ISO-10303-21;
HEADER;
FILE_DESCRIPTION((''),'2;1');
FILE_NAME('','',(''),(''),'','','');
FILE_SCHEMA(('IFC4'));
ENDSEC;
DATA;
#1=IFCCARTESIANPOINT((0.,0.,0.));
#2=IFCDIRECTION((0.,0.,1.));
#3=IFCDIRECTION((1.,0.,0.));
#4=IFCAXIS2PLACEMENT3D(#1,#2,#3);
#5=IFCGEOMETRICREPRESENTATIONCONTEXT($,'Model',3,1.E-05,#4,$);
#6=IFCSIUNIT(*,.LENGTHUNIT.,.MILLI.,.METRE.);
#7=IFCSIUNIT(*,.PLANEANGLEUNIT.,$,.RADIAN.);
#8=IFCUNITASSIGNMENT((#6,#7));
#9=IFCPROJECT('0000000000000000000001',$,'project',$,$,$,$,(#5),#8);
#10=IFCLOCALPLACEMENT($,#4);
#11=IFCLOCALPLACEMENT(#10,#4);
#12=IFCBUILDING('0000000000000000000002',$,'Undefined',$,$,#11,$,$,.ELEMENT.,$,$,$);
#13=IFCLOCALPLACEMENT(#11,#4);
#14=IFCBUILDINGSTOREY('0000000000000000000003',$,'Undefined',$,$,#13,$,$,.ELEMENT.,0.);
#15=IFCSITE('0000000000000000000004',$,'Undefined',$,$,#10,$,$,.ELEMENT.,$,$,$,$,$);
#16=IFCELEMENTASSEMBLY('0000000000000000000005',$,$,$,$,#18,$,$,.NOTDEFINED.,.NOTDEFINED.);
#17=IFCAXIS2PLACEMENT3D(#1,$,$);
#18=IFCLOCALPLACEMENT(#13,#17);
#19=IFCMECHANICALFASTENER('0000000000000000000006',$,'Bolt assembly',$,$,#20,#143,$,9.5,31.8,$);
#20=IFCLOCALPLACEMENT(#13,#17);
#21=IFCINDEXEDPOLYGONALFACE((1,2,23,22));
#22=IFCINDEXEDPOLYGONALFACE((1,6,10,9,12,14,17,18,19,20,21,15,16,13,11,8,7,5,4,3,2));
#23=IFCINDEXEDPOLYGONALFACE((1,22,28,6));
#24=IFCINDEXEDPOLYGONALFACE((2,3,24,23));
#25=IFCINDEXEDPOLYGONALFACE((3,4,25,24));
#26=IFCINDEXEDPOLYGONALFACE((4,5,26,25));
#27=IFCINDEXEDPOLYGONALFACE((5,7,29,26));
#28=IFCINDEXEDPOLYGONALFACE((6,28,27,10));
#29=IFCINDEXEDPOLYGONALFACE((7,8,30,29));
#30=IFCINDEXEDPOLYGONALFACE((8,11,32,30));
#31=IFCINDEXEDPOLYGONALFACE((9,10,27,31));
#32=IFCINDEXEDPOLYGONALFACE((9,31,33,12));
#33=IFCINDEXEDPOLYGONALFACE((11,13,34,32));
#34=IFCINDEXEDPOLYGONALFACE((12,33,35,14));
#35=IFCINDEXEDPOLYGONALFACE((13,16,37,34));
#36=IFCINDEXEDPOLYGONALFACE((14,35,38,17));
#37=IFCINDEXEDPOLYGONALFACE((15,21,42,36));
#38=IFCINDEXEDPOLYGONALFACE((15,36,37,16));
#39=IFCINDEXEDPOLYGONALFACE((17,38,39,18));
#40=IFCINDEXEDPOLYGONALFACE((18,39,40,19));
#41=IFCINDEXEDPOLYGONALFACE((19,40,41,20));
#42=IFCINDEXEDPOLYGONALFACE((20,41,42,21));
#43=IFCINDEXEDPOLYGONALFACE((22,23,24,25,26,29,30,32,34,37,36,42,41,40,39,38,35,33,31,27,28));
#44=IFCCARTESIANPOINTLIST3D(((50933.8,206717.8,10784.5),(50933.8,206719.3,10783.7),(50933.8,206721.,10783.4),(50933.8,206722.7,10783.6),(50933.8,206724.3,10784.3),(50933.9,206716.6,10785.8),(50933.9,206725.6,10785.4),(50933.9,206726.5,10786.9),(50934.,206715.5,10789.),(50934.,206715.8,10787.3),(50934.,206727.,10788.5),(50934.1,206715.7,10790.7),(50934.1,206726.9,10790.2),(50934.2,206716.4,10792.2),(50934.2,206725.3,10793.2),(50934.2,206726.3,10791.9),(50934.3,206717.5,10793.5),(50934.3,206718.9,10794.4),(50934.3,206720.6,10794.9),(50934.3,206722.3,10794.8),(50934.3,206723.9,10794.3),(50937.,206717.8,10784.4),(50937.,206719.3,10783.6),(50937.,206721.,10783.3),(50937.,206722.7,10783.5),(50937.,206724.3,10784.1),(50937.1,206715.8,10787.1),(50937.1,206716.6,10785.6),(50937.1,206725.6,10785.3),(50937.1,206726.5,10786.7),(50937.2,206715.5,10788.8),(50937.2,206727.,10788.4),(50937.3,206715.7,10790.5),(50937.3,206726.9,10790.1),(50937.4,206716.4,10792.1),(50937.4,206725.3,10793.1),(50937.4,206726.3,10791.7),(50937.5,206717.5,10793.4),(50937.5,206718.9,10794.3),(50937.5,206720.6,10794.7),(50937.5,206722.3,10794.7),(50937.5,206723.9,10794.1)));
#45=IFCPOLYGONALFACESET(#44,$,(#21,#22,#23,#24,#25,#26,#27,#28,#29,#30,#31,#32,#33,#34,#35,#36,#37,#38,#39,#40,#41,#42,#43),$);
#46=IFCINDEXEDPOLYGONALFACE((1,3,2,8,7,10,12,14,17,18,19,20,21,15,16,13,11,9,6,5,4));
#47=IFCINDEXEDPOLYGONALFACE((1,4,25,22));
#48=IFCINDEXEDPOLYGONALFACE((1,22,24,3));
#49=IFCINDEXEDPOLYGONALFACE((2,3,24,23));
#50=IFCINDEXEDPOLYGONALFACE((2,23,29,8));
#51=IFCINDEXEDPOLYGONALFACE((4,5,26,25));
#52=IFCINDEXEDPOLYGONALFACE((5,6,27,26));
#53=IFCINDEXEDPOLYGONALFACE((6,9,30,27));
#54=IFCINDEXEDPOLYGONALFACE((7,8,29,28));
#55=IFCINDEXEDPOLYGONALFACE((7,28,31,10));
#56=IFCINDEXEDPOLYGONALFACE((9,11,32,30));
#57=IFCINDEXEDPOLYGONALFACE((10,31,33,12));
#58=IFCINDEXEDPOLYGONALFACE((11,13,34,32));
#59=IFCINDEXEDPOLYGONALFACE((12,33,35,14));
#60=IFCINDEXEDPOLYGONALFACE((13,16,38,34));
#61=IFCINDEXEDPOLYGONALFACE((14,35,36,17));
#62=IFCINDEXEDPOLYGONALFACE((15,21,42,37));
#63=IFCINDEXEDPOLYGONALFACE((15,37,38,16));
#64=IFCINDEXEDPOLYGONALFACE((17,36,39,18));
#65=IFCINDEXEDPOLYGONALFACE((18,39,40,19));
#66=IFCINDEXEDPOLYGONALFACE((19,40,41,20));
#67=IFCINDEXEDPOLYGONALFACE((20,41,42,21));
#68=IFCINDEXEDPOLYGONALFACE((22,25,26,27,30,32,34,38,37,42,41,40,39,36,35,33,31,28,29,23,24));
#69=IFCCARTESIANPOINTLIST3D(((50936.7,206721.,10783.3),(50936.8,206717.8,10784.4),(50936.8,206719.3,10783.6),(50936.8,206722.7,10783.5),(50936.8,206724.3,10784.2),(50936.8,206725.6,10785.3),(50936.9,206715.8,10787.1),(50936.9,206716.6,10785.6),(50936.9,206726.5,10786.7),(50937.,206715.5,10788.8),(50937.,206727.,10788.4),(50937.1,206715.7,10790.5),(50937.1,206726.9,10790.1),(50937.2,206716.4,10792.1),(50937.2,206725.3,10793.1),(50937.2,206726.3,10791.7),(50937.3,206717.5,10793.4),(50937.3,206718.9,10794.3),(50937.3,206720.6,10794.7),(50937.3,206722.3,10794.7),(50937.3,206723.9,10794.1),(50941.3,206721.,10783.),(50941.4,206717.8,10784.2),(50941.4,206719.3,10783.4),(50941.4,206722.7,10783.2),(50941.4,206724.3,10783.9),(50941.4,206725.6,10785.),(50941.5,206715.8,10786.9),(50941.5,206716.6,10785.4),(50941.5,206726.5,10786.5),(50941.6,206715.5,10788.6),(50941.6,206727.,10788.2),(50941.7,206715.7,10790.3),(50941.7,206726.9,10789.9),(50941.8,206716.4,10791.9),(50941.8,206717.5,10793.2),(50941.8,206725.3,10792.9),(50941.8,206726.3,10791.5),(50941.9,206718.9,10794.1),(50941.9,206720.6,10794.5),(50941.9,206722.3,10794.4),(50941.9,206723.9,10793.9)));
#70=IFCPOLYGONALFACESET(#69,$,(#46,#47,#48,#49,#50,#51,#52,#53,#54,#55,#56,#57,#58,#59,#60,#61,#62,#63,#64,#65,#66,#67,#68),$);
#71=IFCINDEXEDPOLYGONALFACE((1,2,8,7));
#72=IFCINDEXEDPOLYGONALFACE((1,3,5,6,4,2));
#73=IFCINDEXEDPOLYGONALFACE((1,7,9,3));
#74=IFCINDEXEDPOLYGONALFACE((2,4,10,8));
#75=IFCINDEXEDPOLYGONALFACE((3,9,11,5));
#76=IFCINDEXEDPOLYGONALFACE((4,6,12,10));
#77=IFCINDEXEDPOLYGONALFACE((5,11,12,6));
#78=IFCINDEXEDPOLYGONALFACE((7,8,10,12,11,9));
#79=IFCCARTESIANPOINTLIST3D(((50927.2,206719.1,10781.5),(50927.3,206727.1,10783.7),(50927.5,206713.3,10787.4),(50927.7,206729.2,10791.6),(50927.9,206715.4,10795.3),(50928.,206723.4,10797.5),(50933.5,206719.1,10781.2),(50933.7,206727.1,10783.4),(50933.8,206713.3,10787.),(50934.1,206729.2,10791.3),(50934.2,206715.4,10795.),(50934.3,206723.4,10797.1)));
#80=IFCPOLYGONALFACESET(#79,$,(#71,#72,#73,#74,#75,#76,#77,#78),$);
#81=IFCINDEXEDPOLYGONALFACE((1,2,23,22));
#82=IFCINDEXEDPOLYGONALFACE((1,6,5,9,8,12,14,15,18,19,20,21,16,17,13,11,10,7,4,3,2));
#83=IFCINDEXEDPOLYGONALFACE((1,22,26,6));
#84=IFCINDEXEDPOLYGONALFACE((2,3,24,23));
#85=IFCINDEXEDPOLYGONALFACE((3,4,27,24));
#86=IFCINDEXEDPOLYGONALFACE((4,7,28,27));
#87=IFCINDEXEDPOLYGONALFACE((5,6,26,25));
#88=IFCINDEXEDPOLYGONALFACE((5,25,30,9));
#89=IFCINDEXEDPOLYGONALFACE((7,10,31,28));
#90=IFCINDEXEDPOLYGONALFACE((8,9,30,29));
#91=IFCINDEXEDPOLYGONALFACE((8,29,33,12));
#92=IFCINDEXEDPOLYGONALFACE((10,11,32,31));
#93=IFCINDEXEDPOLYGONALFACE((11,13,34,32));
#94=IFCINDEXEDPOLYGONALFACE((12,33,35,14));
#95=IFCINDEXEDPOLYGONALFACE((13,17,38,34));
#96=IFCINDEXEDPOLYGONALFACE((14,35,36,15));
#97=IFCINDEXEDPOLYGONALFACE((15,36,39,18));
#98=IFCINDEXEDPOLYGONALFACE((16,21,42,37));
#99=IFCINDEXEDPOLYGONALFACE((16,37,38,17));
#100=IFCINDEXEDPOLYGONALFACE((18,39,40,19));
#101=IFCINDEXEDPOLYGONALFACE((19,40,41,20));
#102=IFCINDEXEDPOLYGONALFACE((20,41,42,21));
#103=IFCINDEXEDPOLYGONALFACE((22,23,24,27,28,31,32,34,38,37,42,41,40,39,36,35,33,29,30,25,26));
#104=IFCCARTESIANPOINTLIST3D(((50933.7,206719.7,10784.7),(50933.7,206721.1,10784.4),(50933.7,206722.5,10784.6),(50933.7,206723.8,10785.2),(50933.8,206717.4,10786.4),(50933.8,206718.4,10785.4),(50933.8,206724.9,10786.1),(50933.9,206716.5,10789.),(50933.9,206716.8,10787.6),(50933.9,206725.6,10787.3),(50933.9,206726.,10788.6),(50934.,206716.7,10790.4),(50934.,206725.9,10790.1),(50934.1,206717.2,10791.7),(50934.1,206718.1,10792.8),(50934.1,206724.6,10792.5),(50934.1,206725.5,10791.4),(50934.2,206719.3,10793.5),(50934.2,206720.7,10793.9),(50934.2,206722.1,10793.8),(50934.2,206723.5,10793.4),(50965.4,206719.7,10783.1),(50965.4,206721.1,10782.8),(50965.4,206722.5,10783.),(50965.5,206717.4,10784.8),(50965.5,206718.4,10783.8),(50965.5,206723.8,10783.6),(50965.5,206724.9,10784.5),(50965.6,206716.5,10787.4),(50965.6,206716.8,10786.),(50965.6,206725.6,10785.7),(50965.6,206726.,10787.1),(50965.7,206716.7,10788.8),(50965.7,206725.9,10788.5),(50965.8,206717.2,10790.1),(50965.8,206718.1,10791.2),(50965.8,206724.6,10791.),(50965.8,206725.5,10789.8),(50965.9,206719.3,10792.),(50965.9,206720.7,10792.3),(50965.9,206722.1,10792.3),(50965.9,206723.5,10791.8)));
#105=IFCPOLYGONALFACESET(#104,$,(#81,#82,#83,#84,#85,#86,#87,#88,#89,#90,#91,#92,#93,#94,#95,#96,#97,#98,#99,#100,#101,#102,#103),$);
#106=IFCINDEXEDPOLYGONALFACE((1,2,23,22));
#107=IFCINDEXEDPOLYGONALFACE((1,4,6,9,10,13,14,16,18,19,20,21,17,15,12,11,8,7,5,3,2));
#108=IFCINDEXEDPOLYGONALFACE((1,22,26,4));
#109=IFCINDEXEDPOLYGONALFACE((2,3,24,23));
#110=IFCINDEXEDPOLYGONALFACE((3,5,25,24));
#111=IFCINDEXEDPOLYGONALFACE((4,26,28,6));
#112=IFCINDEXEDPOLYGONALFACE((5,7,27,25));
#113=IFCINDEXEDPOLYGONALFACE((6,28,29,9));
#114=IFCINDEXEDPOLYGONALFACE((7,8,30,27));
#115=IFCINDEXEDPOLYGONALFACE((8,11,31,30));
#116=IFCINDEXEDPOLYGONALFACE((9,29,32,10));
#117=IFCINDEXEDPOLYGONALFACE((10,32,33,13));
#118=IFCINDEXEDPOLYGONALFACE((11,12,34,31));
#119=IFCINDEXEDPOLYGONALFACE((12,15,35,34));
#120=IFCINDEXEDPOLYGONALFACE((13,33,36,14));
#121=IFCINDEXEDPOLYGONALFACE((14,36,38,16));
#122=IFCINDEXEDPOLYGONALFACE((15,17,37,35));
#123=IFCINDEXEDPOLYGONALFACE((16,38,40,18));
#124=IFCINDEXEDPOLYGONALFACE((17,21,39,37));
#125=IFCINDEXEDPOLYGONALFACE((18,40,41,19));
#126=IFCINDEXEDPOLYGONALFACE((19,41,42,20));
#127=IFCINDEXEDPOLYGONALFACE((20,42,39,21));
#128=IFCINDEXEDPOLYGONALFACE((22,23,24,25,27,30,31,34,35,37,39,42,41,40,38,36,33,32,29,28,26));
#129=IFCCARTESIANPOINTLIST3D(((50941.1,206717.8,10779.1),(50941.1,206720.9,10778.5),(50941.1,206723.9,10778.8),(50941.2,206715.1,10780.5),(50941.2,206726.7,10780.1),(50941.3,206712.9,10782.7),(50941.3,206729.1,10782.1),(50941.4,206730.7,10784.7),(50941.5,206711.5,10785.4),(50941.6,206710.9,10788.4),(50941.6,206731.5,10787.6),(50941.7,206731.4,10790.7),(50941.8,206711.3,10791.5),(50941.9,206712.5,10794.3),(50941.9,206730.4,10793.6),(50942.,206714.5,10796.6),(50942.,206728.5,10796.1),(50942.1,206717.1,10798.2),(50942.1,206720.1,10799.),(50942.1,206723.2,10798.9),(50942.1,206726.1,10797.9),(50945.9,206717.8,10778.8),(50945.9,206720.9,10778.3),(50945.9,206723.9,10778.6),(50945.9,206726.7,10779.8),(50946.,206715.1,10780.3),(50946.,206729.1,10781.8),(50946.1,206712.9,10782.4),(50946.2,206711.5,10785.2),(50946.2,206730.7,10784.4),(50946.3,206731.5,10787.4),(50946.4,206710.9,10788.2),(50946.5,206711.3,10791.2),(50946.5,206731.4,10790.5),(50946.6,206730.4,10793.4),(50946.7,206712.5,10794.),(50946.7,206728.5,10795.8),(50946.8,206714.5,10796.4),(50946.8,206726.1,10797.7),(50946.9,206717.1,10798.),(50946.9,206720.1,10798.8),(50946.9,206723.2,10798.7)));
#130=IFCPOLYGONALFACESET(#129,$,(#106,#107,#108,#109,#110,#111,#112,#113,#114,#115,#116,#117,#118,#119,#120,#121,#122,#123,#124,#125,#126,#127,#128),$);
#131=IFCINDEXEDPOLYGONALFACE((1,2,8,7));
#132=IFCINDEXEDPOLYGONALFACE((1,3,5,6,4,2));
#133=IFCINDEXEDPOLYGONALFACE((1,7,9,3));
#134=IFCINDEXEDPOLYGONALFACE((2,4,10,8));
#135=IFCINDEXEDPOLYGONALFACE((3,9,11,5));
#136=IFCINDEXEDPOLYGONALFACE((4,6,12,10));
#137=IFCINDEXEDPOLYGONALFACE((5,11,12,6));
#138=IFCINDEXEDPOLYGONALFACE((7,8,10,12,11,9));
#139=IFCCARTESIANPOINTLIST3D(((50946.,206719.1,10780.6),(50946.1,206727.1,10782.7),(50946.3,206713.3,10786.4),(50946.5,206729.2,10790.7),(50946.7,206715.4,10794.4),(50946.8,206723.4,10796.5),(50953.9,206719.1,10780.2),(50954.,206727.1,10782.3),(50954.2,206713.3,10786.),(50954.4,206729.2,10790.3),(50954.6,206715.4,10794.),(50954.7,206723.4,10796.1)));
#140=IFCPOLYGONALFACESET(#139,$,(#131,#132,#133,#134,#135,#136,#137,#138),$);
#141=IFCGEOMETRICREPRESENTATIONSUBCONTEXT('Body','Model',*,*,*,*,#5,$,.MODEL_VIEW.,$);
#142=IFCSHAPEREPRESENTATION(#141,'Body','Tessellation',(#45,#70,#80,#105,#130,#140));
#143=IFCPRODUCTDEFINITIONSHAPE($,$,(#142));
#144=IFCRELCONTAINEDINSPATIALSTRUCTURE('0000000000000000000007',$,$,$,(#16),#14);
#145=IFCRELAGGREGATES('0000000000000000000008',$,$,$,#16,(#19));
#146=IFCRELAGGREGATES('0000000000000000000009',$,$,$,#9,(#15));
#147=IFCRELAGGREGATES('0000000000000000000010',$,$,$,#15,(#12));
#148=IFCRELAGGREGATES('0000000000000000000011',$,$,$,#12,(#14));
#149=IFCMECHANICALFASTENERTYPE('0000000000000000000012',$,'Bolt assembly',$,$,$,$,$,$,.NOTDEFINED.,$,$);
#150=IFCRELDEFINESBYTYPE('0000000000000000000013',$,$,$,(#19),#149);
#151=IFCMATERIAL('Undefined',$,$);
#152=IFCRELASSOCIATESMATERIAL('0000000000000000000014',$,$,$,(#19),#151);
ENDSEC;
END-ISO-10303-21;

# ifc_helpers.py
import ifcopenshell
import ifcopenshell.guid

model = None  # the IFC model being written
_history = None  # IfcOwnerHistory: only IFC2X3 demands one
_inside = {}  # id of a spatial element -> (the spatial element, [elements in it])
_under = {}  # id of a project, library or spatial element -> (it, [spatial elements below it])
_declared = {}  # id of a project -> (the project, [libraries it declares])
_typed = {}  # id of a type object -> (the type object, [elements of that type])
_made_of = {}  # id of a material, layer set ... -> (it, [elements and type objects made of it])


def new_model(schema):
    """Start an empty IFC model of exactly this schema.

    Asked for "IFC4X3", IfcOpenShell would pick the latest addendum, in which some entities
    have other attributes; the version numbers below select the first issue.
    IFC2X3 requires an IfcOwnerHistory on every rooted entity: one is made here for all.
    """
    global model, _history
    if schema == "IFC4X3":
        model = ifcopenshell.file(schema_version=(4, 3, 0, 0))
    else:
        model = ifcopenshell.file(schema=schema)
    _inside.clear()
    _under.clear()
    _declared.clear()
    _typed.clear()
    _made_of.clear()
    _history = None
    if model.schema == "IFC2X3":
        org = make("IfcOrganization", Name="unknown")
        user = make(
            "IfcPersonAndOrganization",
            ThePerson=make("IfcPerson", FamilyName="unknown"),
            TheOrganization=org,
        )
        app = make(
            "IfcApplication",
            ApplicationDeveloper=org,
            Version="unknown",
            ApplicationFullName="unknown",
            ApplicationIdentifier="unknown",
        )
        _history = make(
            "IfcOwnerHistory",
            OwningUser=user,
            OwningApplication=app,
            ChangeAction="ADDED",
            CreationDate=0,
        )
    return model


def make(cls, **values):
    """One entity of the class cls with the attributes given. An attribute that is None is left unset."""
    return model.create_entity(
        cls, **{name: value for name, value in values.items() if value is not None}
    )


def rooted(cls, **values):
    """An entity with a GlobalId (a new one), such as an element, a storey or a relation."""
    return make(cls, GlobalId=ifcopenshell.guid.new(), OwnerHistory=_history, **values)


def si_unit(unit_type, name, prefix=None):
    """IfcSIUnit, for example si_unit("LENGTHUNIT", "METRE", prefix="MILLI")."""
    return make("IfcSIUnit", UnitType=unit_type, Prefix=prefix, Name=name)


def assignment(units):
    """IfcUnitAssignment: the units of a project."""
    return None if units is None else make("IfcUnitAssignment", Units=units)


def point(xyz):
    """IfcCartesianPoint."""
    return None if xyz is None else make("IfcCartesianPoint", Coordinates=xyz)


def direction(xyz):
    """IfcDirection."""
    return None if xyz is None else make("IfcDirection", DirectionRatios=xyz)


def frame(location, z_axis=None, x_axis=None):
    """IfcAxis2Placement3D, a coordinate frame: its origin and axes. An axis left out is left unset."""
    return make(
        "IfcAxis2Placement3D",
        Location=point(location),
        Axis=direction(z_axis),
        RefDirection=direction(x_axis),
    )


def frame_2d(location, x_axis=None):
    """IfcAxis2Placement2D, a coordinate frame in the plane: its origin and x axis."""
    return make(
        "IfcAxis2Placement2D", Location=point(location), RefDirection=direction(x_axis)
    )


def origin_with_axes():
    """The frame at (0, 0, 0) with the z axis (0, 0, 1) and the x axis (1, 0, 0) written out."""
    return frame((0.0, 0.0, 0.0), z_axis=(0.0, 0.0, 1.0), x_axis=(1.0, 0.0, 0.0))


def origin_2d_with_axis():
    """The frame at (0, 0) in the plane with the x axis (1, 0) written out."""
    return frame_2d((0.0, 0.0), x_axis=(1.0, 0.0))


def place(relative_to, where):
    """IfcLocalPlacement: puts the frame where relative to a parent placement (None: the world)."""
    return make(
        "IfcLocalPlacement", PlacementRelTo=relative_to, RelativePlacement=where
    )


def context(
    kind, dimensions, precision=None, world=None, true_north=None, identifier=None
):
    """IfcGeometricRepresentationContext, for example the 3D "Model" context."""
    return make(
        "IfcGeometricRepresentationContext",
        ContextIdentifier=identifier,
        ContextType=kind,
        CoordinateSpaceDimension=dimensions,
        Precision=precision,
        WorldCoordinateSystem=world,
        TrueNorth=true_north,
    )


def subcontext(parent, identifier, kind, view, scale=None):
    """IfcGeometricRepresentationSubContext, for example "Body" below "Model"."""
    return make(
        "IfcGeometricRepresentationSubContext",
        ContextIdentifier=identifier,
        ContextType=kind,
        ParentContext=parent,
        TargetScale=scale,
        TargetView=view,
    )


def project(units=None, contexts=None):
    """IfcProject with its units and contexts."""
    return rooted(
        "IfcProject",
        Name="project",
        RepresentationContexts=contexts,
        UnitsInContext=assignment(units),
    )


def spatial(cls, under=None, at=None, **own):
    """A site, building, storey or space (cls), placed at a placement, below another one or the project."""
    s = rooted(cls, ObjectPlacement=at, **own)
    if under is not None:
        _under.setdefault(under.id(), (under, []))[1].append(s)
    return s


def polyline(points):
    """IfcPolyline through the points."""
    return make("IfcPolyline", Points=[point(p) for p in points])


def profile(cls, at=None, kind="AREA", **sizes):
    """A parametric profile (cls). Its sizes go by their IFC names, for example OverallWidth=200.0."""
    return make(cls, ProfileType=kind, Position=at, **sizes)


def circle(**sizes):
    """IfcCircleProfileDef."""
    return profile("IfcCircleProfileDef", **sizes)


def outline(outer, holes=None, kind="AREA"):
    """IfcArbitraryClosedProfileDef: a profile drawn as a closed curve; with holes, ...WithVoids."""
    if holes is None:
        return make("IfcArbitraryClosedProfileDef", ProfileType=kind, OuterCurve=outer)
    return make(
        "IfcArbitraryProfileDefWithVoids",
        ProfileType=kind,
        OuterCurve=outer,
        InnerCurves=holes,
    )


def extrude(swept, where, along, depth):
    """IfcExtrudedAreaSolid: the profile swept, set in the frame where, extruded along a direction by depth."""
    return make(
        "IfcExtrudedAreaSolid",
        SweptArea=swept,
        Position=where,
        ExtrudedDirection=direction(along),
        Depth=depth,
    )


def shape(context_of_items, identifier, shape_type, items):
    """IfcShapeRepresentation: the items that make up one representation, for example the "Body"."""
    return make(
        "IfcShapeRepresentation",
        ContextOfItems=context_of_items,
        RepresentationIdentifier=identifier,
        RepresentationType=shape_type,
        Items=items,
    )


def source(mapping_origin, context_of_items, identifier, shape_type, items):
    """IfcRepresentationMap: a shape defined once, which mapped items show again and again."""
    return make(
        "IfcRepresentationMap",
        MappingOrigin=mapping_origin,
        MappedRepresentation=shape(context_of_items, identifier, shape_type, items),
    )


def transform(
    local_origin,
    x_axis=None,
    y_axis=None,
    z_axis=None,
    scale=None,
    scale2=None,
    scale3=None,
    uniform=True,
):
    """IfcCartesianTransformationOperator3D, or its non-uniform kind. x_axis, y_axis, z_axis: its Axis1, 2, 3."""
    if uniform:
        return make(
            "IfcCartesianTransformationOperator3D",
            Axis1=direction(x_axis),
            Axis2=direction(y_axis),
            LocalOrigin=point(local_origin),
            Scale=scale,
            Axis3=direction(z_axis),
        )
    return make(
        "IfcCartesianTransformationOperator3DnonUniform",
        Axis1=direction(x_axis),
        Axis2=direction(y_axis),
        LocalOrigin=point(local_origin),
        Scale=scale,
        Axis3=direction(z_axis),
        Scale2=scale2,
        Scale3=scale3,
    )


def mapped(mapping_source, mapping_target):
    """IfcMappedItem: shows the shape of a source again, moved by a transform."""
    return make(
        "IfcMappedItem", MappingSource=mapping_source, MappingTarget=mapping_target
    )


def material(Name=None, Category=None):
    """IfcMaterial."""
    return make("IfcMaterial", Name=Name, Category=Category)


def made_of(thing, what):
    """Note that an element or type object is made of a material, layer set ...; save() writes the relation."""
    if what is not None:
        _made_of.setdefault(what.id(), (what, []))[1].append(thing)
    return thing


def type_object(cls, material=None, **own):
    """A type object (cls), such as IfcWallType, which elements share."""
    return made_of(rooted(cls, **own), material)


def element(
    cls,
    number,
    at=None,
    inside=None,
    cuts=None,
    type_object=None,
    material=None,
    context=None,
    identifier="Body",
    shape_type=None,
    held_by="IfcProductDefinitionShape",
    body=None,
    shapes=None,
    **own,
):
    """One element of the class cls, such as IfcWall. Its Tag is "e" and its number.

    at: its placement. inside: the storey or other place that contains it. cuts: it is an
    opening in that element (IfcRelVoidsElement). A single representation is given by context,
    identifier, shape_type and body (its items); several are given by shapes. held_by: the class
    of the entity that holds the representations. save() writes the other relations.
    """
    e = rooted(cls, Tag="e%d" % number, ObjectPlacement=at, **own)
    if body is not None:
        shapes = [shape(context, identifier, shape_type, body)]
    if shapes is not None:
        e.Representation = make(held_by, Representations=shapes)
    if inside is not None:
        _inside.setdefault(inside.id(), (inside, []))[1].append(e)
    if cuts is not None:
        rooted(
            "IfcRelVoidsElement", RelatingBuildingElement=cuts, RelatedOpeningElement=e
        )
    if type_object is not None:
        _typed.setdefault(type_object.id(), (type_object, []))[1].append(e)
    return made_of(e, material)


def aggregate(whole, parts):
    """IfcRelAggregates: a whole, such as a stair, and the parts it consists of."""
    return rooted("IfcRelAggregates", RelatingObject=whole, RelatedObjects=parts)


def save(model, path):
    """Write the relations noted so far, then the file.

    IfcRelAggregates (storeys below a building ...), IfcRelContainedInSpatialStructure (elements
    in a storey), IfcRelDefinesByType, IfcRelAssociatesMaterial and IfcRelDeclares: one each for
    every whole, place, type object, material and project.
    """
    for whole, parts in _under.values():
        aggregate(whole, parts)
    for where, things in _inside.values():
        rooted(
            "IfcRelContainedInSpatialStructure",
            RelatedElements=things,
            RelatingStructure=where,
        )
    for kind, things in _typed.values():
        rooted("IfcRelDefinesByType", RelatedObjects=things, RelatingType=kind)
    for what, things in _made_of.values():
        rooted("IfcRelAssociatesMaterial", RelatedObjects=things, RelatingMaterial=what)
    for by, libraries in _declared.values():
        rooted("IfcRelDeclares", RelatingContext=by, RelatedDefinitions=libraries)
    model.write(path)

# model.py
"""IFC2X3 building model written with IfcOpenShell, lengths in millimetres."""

from ifc_helpers import new_model, si_unit, frame, origin_with_axes, origin_2d_with_axis, place, context, subcontext, project, spatial, polyline, circle, outline, extrude, source, transform, mapped, material, type_object, element, aggregate, save


model = new_model("IFC2X3")

# Units and contexts
model_context = context("Model", 3, precision=1e-05, world=origin_with_axes())
body_context = subcontext(model_context, "Body", "Model", "MODEL_VIEW")
ifc_project = project(units=[si_unit("LENGTHUNIT", "METRE", prefix="MILLI"), si_unit("PLANEANGLEUNIT", "RADIAN")], contexts=[model_context])

# Site, building, storey
site_placement = place(None, origin_with_axes())
site = spatial("IfcSite", under=ifc_project, at=site_placement, Name="Undefined", CompositionType="ELEMENT")
building_placement = place(site_placement, origin_with_axes())
building = spatial("IfcBuilding", under=site, at=building_placement, Name="Undefined", CompositionType="ELEMENT")
storey_placement = place(building_placement, origin_with_axes())
storey = spatial("IfcBuildingStorey", under=building, at=storey_placement, Name="Undefined", CompositionType="ELEMENT", Elevation=0.0)

# Element assembly
assembly_1_placement = place(storey_placement, origin_with_axes())
assembly_1 = element("IfcElementAssembly", 1, at=assembly_1_placement, inside=storey, AssemblyPlace="NOTDEFINED", PredefinedType="NOTDEFINED")

# Shared definitions
ifc_material_1 = material(Name="Undefined")
mechanical_fastener_type = type_object("IfcMechanicalFastenerType", Name="Bolt assembly")

# Mechanical fastener
shared_shape_1 = source(origin_with_axes(), body_context, "Body", "SweptSolid", [
    extrude(circle(Radius=5.8, at=origin_2d_with_axis()), frame((0.0, -7.6, 0.0), z_axis=(0.0, 1.0, 0.0), x_axis=(1.0, 0.0, 0.0)), (0.0, 0.0, 1.0), 3.2),
    extrude(circle(Radius=5.8, at=origin_2d_with_axis()), frame((0.0, -4.6, 0.0), z_axis=(0.0, 1.0, 0.0), x_axis=(1.0, 0.0, 0.0)), (0.0, 0.0, 1.0), 4.6),
    extrude(outline(polyline([(7.1, -4.1), (7.1, 4.1), (0.0, 8.2), (-7.1, 4.1), (-7.1, -4.1), (0.0, -8.2), (7.1, -4.1)])), frame((0.0, -14.0, 0.0), z_axis=(0.0, 1.0, 0.0), x_axis=(1.0, 0.0, 0.0)), (0.0, 0.0, 1.0), 6.3),
    extrude(circle(Radius=4.8, at=origin_2d_with_axis()), frame((0.0, -7.7, 0.0), z_axis=(0.0, 1.0, 0.0), x_axis=(1.0, 0.0, 0.0)), (0.0, 0.0, 1.0), 31.8),
    extrude(circle(Radius=10.3, at=origin_2d_with_axis()), frame((0.0, 0.0, 0.0), z_axis=(0.0, 1.0, 0.0), x_axis=(1.0, 0.0, 0.0)), (0.0, 0.0, 1.0), 4.8),
    extrude(outline(polyline([(7.1, -4.1), (7.1, 4.1), (0.0, 8.2), (-7.1, 4.1), (-7.1, -4.1), (0.0, -8.2), (7.1, -4.1)])), frame((0.0, 4.8, 0.0), z_axis=(0.0, 1.0, 0.0), x_axis=(1.0, 0.0, 0.0)), (0.0, 0.0, 1.0), 7.9),
])
mechanical_fastener_1_placement = place(assembly_1_placement, frame((50941.6, 206721.2, 10788.8), z_axis=(-0.035281, 0.707107, -0.706226), x_axis=(0.035282, 0.707107, 0.706226)))
mechanical_fastener_1 = element("IfcMechanicalFastener", 2, at=mechanical_fastener_1_placement, type_object=mechanical_fastener_type, material=ifc_material_1, Name="Bolt assembly", NominalDiameter=9.5, NominalLength=31.8, context=body_context, shape_type="MappedRepresentation", body=[
    mapped(shared_shape_1, transform((0.0, 0.0, 0.0))),
])
aggregate(assembly_1, [mechanical_fastener_1])

save(model, "model.ifc")
